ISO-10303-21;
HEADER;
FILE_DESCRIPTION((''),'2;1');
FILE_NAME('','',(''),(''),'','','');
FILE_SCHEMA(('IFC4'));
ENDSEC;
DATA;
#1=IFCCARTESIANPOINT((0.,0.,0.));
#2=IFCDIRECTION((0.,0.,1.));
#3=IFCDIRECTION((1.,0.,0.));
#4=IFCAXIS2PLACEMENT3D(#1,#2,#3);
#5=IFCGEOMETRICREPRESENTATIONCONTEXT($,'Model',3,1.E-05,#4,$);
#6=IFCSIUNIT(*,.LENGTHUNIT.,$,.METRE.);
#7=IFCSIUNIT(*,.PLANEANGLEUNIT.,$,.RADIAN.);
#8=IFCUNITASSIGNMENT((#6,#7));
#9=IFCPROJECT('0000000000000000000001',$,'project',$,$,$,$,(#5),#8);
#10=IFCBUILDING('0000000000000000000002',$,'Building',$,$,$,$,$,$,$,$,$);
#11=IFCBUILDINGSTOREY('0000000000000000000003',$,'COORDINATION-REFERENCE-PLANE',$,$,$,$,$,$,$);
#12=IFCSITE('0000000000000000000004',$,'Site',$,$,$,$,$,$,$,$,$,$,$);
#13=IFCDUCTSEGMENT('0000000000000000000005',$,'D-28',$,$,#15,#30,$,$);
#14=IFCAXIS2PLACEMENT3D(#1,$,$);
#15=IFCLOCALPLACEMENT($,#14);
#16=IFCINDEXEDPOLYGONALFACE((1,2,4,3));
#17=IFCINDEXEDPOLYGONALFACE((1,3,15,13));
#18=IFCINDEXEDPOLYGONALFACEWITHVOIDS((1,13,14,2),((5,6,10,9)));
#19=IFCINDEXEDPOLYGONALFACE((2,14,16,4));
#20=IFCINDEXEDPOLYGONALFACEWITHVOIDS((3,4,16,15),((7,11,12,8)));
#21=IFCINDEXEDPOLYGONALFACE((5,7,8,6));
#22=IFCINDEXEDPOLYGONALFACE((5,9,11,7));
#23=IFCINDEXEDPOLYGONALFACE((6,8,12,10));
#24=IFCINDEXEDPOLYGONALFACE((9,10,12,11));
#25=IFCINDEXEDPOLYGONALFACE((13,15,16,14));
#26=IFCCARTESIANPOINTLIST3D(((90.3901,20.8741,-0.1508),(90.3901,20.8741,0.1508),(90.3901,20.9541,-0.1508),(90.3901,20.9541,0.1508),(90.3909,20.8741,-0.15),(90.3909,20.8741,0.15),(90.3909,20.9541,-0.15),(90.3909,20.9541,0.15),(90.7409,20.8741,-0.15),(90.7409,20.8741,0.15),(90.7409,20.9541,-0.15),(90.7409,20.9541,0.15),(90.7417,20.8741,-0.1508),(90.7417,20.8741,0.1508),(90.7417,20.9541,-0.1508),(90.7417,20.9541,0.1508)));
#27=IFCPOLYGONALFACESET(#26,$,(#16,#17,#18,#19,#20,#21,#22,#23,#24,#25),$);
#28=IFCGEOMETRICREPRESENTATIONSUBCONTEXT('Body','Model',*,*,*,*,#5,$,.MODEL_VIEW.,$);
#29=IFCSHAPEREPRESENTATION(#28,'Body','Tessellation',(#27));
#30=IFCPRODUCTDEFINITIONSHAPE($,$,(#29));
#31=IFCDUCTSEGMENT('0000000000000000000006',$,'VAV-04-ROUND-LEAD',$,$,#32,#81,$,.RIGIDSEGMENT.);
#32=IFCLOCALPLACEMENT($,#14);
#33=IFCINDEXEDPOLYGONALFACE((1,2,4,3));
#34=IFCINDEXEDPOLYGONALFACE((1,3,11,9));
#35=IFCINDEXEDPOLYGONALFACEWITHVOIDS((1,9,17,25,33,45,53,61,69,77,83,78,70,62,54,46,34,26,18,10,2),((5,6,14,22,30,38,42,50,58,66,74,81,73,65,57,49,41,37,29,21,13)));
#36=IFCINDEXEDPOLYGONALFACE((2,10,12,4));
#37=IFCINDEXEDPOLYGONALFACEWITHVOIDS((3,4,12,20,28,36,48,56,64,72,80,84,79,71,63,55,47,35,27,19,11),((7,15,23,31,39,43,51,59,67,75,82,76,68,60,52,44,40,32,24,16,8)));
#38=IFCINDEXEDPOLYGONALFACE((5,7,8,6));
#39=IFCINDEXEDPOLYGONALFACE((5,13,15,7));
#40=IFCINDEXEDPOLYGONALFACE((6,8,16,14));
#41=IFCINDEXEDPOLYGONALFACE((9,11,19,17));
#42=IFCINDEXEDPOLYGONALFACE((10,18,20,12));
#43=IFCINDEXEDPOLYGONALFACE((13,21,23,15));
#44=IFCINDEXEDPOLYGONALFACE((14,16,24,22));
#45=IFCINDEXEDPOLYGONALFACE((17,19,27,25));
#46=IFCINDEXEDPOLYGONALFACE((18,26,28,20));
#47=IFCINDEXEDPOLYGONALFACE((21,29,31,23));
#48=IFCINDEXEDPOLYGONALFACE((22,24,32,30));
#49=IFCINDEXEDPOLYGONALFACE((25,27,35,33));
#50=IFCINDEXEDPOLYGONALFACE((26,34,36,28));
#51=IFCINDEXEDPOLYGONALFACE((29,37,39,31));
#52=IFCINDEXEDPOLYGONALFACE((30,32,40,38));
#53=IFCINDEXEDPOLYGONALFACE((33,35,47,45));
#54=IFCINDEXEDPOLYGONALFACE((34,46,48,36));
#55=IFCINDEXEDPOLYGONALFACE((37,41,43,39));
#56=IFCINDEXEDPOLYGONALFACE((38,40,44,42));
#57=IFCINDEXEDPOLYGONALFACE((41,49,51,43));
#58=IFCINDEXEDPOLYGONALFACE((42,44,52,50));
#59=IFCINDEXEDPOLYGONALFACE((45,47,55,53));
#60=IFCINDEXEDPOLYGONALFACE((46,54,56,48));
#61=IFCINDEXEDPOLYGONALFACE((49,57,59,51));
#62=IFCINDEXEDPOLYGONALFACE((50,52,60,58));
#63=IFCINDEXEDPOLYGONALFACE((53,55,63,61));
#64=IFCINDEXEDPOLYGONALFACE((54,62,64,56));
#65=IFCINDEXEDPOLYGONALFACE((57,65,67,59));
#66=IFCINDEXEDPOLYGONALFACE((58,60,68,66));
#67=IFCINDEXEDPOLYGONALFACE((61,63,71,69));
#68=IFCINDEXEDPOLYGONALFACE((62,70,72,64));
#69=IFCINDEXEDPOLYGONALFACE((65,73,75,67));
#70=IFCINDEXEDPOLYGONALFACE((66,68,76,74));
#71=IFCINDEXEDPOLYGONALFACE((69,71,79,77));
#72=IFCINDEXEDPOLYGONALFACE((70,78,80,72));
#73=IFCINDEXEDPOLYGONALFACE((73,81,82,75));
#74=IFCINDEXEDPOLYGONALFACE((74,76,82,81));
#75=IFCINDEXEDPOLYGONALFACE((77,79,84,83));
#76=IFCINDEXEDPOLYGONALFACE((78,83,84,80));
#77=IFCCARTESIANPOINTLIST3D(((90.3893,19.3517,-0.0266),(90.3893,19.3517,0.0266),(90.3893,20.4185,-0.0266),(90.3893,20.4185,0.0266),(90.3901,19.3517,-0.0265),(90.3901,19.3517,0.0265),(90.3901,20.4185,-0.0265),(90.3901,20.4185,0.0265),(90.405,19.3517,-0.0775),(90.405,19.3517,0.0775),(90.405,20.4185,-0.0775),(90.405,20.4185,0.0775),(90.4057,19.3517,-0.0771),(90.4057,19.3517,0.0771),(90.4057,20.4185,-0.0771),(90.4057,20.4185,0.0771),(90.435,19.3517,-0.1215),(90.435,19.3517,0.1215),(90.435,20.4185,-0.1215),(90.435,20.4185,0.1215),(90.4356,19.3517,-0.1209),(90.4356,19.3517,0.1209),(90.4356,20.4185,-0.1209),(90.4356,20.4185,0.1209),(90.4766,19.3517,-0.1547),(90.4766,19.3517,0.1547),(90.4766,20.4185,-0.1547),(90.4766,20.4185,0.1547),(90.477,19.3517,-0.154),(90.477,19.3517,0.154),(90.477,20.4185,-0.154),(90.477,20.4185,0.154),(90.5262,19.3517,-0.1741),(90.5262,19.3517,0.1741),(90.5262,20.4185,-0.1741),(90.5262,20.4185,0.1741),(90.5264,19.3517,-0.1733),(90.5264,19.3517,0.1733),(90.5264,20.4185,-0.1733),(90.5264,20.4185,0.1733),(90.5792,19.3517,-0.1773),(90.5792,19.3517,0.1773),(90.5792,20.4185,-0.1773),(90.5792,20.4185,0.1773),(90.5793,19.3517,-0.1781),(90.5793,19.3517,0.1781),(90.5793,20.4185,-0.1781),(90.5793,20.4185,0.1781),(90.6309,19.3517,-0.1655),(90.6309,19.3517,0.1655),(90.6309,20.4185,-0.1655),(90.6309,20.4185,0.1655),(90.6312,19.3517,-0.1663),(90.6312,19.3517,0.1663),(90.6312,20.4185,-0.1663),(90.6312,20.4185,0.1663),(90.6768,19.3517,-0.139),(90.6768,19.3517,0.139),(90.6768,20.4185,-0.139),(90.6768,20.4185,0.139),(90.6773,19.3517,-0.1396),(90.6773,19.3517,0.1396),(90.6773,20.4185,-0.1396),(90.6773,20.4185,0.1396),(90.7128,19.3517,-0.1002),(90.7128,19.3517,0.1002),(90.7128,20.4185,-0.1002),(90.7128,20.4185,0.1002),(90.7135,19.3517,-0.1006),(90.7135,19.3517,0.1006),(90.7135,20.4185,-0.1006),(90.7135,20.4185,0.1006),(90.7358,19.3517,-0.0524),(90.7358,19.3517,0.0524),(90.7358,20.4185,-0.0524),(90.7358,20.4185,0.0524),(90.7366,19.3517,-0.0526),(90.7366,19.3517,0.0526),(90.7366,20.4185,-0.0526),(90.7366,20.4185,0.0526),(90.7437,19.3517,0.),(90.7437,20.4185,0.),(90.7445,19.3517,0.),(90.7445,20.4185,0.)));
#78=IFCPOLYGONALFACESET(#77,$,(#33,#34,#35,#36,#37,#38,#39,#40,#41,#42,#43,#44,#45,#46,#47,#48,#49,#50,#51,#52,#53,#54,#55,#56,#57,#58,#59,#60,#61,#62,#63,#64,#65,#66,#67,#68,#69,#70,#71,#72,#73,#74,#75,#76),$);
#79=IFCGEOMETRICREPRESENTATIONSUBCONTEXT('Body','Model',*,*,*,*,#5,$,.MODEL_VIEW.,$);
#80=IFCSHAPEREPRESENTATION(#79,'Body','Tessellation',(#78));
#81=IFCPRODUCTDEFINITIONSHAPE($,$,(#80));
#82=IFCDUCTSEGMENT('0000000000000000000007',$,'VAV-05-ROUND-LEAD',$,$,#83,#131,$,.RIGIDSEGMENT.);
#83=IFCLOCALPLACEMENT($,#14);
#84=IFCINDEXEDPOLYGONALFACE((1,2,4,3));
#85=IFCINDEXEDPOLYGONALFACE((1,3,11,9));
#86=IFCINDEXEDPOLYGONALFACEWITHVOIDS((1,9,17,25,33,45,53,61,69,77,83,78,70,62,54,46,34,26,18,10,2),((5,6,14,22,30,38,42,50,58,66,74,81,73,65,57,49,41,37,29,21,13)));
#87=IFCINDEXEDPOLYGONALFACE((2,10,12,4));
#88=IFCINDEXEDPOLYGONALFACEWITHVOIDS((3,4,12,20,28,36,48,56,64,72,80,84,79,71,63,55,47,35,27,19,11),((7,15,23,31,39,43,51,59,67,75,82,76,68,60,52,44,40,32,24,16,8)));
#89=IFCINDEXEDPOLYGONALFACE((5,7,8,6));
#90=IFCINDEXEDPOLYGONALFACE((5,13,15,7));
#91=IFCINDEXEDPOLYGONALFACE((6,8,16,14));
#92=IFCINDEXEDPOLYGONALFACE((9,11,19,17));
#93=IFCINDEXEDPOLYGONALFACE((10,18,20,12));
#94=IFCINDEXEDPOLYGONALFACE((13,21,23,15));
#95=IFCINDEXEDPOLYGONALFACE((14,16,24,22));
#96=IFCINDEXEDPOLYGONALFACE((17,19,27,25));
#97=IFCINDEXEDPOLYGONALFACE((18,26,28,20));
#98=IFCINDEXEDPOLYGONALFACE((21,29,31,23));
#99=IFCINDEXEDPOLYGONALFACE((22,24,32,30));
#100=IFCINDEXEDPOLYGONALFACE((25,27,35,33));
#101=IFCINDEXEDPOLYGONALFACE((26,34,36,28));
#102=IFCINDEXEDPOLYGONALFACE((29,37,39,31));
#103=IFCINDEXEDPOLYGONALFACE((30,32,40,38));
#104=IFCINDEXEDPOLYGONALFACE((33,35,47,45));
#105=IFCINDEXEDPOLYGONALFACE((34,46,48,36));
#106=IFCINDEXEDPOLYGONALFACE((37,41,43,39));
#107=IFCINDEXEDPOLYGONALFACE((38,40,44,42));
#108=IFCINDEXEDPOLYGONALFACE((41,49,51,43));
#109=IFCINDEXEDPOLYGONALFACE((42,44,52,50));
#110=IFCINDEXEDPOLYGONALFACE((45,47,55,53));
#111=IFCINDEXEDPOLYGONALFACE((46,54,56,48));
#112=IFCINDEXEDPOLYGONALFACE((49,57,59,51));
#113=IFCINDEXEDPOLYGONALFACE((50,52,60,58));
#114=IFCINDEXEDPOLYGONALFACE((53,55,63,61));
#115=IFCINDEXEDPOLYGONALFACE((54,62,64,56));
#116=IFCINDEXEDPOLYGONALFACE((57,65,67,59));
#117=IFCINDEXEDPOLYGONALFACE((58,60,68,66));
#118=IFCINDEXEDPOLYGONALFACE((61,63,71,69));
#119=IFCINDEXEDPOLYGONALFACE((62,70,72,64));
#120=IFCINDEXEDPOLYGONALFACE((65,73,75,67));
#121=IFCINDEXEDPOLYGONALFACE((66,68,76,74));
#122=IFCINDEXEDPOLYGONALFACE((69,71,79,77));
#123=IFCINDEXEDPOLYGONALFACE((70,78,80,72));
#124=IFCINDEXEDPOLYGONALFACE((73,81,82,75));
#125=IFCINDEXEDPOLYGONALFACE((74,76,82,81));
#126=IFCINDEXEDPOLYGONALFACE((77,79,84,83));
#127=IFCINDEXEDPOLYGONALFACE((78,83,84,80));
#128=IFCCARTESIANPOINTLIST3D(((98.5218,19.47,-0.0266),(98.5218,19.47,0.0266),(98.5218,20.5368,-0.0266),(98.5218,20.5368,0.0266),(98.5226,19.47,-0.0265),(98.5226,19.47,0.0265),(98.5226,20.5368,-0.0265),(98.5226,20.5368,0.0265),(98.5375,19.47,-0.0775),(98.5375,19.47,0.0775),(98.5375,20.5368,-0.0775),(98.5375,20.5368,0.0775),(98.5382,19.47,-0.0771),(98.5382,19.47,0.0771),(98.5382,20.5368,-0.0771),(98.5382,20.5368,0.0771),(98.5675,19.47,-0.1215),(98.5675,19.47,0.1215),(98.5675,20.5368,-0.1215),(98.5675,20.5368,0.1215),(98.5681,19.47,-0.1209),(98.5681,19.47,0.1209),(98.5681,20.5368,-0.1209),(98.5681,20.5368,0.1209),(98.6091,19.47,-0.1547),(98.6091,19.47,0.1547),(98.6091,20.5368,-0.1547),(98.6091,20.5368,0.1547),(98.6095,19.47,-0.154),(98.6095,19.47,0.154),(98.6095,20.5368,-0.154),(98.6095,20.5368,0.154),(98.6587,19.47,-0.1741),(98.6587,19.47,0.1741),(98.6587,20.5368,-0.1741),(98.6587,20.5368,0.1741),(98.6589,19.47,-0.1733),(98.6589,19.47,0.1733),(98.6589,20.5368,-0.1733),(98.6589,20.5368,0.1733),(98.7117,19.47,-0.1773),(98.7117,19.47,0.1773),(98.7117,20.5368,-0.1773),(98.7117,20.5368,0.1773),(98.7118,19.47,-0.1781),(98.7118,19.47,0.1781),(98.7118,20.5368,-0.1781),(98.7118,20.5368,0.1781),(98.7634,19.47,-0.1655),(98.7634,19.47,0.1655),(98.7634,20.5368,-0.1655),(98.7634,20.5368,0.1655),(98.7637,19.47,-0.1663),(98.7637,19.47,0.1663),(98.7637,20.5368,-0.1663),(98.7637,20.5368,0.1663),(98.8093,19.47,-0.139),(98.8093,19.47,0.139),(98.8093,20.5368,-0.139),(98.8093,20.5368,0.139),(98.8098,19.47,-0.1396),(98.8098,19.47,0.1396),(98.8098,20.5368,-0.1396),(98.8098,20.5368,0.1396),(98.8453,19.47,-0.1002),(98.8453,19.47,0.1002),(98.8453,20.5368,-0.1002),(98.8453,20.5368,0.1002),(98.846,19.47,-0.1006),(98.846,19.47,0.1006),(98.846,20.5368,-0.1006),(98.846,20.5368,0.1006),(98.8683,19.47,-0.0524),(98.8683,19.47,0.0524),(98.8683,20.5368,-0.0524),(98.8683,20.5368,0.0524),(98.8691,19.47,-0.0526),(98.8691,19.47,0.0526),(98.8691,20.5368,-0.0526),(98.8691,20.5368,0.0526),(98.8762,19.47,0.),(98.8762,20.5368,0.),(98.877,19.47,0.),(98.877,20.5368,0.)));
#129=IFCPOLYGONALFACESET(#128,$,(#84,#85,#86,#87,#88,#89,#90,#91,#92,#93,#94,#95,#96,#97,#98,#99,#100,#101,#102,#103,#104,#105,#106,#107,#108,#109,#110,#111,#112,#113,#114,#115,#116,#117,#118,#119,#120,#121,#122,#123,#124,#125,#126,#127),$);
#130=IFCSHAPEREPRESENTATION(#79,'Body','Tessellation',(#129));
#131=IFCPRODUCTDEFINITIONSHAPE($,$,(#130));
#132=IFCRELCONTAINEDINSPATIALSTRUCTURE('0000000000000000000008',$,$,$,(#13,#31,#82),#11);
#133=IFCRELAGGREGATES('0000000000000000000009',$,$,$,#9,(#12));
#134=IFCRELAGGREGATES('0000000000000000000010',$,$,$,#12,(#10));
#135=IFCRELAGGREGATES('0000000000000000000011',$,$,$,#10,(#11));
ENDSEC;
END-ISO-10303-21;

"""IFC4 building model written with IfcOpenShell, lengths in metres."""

from ifc_helpers import new_model, si_unit, frame, origin, origin_with_axes, place, context, subcontext, project, spatial, hollow_rectangle, hollow_circle, extrude, element, save


model = new_model("IFC4")

# Units and contexts
model_context = context("Model", 3, precision=1e-05, world=origin_with_axes())
body_context_1 = subcontext(model_context, "Body", "Model", "MODEL_VIEW")
body_context_2 = subcontext(model_context, "Body", "Model", "MODEL_VIEW")
ifc_project = project(units=[si_unit("LENGTHUNIT", "METRE"), si_unit("PLANEANGLEUNIT", "RADIAN")], contexts=[model_context])

# Site, building, storey
site = spatial("IfcSite", under=ifc_project, Name="Site")
building = spatial("IfcBuilding", under=site, Name="Building")
storey = spatial("IfcBuildingStorey", under=building, Name="COORDINATION-REFERENCE-PLANE")

# Duct segments
duct_segment_1_placement = place(None, frame((90.5659, 20.8741, 0.0), z_axis=(0.0, 1.0, 0.0), x_axis=(1.0, 0.0, 0.0)))
element("IfcDuctSegment", 1, at=duct_segment_1_placement, inside=storey, Name="D-28", context=body_context_1, shape_type="SweptSolid", body=[
    extrude(hollow_rectangle(XDim=0.3516, YDim=0.3016, WallThickness=0.0008), origin(), (0.0, 0.0, 1.0), 0.08),
])
for number, where, z_axis, x_axis, name in (
    (2, (90.5659, 20.4185, 0.0), (0.0, -1.0, 0.0), (1.0, 0.0, 0.0), "VAV-04-ROUND-LEAD"),
    (3, (98.6984, 20.5368, 0.0), (0.0, -1.0, 0.0), (1.0, 0.0, 0.0), "VAV-05-ROUND-LEAD"),
):
    element("IfcDuctSegment", number, at=place(None, frame(where, z_axis=z_axis, x_axis=x_axis)), inside=storey, Name=name, PredefinedType="RIGIDSEGMENT", context=body_context_2, shape_type="SweptSolid", body=[
        extrude(hollow_circle(Radius=0.1786, WallThickness=0.0008), origin(), (0.0, 0.0, 1.0), 1.0668),
    ])

save(model, "model.ifc")
